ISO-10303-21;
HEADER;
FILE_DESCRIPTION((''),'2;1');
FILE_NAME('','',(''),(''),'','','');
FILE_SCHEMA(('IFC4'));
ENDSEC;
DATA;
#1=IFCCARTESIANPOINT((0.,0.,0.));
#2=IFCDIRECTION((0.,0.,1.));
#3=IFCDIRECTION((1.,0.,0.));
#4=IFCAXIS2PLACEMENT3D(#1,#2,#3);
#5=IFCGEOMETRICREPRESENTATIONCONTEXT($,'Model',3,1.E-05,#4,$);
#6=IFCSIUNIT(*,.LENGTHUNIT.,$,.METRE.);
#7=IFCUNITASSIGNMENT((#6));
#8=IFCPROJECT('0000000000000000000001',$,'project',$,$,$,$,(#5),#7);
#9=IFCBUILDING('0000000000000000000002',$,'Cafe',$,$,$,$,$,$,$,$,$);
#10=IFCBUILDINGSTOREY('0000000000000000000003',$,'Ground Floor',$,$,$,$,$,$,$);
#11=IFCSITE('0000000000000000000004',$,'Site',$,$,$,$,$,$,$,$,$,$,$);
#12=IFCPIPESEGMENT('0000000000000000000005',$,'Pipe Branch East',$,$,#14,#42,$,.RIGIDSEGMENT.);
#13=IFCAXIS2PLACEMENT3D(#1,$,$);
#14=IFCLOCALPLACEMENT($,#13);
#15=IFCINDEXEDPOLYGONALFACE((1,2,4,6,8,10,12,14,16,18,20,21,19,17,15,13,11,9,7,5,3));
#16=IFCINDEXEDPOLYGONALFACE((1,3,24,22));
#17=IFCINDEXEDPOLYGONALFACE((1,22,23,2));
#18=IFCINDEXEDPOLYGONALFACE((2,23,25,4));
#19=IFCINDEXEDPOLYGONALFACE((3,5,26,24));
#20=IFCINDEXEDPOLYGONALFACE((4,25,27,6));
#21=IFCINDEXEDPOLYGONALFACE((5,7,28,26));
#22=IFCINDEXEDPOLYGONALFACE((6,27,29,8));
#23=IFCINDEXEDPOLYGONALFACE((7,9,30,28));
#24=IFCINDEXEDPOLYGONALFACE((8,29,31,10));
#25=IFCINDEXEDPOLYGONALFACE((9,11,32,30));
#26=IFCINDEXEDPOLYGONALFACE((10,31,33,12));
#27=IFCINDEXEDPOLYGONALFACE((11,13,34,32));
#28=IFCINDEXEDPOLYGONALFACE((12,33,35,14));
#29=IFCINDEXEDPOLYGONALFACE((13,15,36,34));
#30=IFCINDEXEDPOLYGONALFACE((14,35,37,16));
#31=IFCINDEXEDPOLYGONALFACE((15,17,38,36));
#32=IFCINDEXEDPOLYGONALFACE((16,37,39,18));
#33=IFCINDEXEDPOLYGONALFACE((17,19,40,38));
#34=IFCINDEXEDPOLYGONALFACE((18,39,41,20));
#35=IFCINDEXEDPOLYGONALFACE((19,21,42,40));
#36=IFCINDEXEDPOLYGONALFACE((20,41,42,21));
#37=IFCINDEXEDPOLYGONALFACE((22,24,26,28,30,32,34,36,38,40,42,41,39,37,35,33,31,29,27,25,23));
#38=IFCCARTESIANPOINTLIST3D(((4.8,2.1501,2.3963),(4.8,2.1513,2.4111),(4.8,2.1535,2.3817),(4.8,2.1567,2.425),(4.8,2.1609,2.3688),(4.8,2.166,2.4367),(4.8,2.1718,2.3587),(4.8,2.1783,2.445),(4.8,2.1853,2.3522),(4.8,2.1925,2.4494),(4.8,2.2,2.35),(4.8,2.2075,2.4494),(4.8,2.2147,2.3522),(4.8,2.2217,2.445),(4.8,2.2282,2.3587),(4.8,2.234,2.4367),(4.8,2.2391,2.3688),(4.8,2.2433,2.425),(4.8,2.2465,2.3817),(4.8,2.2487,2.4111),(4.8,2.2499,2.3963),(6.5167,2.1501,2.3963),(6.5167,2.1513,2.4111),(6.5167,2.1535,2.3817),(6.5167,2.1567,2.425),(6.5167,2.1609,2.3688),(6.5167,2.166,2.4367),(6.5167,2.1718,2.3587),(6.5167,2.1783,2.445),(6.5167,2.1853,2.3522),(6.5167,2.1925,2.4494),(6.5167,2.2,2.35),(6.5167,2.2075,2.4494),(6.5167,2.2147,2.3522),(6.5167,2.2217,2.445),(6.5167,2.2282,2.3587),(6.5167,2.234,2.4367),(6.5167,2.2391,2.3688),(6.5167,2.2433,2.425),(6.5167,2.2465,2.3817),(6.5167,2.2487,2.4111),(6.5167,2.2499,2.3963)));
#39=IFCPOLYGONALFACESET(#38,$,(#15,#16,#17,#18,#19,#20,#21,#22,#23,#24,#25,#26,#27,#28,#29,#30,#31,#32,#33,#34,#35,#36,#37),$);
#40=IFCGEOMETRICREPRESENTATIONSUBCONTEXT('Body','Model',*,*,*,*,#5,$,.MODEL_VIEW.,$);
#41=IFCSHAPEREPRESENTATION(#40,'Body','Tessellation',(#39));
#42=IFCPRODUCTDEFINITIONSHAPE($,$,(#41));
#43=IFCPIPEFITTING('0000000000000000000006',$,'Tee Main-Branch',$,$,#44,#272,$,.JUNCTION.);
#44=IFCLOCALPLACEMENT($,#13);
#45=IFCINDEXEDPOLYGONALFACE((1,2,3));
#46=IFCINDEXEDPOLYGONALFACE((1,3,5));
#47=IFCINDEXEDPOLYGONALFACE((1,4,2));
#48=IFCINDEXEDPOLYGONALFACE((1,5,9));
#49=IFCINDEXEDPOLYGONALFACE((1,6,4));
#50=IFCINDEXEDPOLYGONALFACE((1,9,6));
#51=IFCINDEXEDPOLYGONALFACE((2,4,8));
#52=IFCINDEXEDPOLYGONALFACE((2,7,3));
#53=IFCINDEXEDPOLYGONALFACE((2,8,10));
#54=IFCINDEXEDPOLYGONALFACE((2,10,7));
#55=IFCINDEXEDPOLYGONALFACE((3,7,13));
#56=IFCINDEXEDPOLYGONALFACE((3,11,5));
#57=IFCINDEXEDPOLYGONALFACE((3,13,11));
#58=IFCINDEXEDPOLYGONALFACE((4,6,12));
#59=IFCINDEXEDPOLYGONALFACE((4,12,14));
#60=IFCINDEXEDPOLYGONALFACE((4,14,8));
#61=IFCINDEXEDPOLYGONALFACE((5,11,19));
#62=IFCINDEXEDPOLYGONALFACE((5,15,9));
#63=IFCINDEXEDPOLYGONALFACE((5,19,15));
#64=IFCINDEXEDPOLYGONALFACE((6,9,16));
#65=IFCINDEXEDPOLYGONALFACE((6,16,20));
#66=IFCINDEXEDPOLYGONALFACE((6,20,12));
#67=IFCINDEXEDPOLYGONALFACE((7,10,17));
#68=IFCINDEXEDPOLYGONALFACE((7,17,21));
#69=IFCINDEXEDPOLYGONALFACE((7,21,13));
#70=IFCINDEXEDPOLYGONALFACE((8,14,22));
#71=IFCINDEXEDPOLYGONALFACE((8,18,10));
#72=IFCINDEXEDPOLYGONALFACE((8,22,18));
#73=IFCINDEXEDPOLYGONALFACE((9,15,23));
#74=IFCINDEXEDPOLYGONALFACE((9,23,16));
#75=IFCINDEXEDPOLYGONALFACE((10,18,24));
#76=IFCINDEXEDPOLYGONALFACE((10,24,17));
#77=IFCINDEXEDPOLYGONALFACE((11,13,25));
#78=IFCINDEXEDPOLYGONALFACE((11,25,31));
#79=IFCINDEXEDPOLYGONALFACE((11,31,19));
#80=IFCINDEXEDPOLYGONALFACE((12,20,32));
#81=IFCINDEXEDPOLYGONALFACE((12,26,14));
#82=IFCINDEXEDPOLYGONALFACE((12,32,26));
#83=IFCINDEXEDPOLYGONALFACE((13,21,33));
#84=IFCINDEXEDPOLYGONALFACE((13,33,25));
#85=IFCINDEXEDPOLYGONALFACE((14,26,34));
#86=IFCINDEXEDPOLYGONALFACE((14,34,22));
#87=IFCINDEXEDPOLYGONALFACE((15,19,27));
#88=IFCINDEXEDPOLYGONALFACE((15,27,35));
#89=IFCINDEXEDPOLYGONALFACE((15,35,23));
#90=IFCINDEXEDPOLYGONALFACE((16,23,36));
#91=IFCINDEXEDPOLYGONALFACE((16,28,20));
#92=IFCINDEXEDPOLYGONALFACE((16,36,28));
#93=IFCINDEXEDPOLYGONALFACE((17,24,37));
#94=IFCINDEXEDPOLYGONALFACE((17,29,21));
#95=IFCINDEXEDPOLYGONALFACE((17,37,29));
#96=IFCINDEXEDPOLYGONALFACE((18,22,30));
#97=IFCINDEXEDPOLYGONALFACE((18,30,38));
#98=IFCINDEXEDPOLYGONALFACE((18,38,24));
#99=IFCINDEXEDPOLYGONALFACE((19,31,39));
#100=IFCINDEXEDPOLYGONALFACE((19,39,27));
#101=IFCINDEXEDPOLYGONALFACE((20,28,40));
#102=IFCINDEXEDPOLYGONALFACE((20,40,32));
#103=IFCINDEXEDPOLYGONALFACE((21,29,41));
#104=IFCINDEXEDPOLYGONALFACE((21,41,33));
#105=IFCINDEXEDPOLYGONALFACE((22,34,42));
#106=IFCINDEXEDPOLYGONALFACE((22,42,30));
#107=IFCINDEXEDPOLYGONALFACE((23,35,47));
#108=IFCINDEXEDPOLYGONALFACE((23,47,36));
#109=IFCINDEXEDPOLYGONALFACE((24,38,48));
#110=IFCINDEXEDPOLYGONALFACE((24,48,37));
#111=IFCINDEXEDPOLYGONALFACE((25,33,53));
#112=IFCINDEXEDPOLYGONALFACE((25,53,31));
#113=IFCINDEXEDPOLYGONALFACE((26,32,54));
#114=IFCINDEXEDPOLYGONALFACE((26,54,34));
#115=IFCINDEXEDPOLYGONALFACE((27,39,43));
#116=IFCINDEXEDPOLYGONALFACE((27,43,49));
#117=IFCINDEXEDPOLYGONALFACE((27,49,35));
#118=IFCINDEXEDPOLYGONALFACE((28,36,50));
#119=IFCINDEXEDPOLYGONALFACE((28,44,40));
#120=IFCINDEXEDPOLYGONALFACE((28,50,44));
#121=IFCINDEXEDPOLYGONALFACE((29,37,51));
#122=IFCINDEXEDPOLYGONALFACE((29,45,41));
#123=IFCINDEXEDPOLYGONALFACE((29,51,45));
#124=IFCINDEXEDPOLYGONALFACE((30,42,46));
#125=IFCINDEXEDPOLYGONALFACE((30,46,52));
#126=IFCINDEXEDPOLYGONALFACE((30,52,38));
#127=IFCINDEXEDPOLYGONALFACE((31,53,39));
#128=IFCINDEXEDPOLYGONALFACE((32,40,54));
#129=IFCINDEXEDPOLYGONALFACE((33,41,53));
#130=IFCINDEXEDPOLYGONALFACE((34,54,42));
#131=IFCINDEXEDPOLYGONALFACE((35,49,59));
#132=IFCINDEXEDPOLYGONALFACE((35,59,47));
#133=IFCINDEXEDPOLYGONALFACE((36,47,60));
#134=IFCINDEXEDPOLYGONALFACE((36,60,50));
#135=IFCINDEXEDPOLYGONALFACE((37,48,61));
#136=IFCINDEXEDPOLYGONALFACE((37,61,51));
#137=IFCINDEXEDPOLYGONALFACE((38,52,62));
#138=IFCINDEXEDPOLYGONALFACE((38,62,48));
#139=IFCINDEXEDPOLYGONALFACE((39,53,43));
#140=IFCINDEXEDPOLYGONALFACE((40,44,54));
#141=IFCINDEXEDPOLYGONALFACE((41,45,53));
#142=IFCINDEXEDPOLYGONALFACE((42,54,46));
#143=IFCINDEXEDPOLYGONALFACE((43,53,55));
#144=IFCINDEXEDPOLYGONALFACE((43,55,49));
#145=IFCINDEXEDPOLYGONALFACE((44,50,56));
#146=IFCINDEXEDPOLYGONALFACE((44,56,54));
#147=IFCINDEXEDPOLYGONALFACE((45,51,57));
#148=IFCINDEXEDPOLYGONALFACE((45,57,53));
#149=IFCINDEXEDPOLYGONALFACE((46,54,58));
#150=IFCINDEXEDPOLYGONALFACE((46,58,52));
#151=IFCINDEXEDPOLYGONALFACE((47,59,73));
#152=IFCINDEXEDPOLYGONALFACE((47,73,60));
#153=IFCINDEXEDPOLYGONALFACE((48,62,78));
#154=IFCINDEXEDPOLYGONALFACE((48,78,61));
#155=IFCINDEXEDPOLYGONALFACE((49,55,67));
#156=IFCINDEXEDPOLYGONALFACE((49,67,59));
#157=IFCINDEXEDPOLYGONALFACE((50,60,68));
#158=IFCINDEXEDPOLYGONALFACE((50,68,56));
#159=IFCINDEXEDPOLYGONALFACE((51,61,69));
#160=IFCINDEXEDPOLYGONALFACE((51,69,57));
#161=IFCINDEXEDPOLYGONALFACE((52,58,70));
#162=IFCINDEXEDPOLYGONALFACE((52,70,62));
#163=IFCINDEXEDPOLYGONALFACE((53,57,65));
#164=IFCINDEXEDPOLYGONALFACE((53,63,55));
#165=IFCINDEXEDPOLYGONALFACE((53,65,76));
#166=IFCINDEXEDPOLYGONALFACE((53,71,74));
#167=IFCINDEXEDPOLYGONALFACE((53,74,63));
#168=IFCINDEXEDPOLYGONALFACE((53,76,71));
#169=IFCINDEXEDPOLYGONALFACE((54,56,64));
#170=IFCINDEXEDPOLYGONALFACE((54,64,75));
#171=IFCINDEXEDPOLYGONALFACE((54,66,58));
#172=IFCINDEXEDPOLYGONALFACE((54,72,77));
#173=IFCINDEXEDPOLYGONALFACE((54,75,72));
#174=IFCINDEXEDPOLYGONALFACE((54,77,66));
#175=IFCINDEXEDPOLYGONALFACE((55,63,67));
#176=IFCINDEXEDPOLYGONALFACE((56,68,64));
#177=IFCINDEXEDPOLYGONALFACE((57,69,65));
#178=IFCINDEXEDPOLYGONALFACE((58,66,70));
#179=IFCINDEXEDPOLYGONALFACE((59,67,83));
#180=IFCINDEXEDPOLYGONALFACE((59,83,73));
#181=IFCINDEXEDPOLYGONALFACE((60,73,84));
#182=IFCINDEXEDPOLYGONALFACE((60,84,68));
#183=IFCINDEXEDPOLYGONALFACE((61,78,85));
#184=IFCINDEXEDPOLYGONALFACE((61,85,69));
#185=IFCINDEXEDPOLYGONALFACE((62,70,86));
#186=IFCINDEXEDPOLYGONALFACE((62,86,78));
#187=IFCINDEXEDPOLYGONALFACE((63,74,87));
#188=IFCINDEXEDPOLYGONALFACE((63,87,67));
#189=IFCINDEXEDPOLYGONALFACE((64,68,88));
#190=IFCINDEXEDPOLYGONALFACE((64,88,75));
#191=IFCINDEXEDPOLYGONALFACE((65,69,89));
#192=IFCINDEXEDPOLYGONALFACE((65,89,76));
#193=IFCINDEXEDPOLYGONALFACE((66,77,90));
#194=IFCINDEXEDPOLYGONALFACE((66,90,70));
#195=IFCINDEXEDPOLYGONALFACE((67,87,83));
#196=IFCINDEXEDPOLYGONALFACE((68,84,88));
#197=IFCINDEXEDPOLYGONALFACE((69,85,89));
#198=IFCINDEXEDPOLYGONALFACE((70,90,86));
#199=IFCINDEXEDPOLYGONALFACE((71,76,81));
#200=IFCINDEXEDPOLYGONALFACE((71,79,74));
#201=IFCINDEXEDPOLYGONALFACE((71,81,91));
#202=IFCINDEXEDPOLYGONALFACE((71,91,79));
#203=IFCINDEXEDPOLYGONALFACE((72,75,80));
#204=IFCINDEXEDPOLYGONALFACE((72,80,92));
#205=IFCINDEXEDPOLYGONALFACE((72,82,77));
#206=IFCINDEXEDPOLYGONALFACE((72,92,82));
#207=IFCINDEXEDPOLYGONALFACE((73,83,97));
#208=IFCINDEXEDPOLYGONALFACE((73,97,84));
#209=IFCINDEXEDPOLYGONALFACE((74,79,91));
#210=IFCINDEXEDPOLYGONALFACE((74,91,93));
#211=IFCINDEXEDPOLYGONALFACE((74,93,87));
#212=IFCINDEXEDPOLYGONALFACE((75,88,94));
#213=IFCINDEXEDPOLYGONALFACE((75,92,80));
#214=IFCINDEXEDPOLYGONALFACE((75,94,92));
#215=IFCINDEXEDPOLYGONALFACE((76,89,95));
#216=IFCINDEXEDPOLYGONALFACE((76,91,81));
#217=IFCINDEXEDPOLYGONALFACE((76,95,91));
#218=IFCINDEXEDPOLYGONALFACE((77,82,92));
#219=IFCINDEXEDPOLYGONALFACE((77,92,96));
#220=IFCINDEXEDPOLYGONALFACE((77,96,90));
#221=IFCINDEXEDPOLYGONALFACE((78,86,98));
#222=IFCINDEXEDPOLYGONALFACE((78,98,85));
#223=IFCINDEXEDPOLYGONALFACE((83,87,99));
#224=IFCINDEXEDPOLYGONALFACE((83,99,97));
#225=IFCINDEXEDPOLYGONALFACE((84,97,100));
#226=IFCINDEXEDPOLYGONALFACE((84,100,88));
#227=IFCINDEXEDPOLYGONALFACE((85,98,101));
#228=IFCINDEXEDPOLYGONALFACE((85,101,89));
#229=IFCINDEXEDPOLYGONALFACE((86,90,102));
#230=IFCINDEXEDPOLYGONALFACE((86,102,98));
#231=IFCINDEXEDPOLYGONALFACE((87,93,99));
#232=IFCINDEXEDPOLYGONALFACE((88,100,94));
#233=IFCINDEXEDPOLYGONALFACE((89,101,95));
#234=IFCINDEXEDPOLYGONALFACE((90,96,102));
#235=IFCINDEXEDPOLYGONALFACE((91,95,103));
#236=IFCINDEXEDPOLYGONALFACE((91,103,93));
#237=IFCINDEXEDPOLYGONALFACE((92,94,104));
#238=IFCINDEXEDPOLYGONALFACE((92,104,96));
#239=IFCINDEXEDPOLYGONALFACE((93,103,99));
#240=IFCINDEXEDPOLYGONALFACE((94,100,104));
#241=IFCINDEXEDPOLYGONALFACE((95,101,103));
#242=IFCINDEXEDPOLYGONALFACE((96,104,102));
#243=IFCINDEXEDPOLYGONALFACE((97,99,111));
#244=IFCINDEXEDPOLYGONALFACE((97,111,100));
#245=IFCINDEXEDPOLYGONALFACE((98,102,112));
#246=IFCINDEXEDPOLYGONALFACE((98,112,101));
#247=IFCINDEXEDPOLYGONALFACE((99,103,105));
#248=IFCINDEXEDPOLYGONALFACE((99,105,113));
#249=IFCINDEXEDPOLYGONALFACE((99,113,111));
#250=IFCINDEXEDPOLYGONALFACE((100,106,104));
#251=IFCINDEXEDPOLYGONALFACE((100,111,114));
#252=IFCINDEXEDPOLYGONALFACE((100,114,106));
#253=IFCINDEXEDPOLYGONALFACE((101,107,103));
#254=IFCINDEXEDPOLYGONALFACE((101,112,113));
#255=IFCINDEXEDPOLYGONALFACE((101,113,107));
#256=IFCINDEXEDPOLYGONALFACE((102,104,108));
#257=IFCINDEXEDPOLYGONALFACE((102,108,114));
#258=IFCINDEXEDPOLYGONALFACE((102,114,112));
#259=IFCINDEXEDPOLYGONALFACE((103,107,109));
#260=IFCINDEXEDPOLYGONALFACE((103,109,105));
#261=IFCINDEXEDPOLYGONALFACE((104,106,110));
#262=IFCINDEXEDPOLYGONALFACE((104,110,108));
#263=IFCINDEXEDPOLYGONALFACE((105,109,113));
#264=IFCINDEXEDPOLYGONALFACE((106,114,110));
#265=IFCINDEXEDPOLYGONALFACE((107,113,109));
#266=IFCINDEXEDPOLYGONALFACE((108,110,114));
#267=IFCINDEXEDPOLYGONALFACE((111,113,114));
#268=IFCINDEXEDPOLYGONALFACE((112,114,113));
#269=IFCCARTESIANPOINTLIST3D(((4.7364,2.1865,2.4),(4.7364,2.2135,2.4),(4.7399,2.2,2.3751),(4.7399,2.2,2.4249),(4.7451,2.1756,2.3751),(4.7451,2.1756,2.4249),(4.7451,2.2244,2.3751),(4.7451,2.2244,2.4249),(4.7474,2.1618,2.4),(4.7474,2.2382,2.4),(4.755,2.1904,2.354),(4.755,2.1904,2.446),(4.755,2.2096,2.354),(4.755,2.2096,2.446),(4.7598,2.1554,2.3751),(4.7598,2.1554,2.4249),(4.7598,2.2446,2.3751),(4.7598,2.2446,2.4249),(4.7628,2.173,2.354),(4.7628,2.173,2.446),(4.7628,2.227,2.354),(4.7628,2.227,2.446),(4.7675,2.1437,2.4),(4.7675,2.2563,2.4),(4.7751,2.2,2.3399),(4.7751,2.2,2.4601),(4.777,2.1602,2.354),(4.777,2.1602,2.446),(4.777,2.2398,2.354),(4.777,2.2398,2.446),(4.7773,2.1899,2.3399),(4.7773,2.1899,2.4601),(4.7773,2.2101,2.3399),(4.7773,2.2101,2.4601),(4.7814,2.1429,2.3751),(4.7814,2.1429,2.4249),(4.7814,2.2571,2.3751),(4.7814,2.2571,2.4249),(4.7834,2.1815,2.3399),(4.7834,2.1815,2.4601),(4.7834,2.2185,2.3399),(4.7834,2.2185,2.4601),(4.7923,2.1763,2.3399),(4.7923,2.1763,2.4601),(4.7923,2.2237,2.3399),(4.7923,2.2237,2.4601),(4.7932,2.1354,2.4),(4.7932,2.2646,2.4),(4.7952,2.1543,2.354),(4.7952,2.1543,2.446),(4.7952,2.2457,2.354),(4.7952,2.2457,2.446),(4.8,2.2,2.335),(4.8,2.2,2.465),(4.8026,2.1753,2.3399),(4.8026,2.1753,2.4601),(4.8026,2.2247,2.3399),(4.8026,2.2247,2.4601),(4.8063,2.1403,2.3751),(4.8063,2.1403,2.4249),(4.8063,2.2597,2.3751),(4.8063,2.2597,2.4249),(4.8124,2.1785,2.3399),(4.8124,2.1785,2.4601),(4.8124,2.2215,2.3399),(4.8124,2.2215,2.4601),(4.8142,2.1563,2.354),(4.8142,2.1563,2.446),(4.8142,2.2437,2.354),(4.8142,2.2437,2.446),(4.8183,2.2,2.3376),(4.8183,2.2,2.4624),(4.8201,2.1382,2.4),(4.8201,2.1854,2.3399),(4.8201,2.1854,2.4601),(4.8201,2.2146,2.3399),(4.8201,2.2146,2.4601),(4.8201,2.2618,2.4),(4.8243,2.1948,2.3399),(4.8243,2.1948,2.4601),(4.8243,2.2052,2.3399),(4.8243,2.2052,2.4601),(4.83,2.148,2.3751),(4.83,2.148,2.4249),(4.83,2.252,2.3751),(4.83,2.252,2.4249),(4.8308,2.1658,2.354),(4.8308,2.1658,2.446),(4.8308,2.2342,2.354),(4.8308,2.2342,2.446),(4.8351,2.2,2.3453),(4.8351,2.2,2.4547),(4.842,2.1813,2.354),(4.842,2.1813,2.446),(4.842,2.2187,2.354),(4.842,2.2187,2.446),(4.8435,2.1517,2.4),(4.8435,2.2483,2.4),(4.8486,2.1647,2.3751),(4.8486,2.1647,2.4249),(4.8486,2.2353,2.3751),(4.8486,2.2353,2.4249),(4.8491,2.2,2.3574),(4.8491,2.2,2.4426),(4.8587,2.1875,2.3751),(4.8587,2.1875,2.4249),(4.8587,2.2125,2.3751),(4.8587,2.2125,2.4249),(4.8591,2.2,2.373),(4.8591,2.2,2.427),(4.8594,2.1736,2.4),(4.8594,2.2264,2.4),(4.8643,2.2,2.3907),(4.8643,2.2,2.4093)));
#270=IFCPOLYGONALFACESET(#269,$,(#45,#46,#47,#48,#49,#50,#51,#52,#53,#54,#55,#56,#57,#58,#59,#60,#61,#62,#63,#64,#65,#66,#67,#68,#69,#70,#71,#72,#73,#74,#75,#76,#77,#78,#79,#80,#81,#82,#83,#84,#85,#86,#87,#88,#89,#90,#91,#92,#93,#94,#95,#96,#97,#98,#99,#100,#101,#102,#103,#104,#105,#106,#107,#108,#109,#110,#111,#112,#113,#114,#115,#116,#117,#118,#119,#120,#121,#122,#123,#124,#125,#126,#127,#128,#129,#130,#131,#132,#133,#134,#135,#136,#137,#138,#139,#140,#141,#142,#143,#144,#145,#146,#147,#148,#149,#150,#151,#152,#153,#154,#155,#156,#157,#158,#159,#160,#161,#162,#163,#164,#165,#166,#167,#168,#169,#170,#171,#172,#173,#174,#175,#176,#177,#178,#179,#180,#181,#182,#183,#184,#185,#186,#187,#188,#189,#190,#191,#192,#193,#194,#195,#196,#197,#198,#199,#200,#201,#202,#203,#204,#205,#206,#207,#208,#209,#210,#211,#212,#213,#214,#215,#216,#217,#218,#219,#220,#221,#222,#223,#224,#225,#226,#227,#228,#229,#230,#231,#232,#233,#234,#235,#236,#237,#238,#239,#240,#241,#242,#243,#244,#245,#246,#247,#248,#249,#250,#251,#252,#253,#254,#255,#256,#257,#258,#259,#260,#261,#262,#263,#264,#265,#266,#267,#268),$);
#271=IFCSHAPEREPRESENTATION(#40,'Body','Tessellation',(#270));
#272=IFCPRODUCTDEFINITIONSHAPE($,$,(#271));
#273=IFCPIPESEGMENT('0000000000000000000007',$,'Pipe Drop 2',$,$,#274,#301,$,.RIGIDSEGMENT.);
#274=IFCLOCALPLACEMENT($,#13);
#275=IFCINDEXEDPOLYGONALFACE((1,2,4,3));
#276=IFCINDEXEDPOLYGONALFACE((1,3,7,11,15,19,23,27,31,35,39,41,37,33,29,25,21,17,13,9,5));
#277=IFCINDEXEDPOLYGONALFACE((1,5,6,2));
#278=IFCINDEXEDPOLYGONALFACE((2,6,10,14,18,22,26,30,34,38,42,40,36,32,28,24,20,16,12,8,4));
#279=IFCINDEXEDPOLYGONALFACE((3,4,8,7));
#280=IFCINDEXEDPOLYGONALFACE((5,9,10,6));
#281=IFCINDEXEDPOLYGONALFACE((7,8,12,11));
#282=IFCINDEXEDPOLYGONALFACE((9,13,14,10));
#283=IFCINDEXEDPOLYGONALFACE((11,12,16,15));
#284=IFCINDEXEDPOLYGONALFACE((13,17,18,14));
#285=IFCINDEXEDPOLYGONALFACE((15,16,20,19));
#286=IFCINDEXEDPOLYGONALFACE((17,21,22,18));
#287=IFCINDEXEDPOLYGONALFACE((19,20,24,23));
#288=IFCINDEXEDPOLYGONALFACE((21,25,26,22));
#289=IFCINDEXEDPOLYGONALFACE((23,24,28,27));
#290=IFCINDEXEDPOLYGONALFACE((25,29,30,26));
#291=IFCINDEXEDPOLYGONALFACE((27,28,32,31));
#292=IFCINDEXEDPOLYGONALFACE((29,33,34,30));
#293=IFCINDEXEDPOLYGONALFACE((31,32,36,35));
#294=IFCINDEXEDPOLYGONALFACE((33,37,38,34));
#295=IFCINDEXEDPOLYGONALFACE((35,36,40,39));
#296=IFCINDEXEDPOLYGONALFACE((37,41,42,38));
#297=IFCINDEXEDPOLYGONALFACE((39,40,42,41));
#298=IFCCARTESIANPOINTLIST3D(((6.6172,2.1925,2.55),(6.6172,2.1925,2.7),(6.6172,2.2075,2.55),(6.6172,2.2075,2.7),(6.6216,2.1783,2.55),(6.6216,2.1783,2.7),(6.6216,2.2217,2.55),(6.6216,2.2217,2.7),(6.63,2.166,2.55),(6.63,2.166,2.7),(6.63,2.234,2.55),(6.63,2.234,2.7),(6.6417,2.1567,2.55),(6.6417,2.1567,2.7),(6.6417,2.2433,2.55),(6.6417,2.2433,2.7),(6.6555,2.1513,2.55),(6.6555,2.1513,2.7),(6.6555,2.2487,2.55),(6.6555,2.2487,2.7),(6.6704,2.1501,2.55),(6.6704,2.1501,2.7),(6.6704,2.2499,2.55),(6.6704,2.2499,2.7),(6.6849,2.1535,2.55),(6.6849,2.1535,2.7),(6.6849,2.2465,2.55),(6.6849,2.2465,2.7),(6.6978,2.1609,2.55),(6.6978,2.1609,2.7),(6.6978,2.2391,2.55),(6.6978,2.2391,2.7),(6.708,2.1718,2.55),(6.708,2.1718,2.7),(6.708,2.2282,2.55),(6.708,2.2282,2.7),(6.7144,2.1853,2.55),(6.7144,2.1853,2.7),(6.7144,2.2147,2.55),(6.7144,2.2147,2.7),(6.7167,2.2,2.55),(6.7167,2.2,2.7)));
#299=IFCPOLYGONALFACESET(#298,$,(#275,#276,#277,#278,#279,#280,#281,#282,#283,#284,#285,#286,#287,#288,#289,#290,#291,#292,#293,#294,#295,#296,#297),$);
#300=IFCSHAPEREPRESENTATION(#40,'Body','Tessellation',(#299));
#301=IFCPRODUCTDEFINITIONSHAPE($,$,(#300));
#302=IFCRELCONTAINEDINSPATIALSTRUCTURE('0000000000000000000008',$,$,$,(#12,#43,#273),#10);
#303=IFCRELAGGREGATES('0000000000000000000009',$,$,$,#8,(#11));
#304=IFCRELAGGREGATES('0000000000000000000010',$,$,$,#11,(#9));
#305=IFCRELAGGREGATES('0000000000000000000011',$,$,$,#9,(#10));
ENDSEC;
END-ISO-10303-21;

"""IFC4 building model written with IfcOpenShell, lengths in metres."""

from ifc_helpers import new_model, entity, si_unit, frame, origin, origin_with_axes, origin_2d, place, context, subcontext, project, spatial, circle, extrude, element, save


model = new_model("IFC4")

# Units and contexts
model_context = context("Model", 3, precision=1e-05, world=origin_with_axes())
body_context = subcontext(model_context, "Body", "Model", "MODEL_VIEW")
ifc_project = project(units=[si_unit("LENGTHUNIT", "METRE")], contexts=[model_context])

# Site, building, storey
site = spatial("IfcSite", under=ifc_project, Name="Site")
building = spatial("IfcBuilding", under=site, Name="Cafe")
storey = spatial("IfcBuildingStorey", under=building, Name="Ground Floor")

# Pipe segment
pipe_segment_1_placement = place(None, frame((4.8, 2.2, 2.4), z_axis=(1.0, 0.0, 0.0), x_axis=(0.0, 0.0, -1.0)))
element("IfcPipeSegment", 1, at=pipe_segment_1_placement, inside=storey, Name="Pipe Branch East", PredefinedType="RIGIDSEGMENT", context=body_context, shape_type="SweptSolid", body=[
    extrude(circle(Radius=0.05, at=origin_2d()), origin(), (0.0, 0.0, 1.0), 1.7167),
])

# Pipe fitting
pipe_fitting_1_placement = place(None, frame((4.8, 2.2, 2.4), z_axis=(0.0, 0.0, 1.0), x_axis=(1.0, 0.0, 0.0)))
element("IfcPipeFitting", 2, at=pipe_fitting_1_placement, inside=storey, Name="Tee Main-Branch", PredefinedType="JUNCTION", context=body_context, shape_type="CSG", body=[
    entity("IfcCsgSolid", entity("IfcSphere", entity("IfcAxis2Placement3D", entity("IfcCartesianPoint", [0.0, 0.0, 0.0])), 0.065)),
])

# Pipe segment
pipe_segment_2_placement = place(None, frame((6.6667, 2.2, 2.55), z_axis=(0.0, 0.0, 1.0), x_axis=(1.0, 0.0, 0.0)))
element("IfcPipeSegment", 3, at=pipe_segment_2_placement, inside=storey, Name="Pipe Drop 2", PredefinedType="RIGIDSEGMENT", context=body_context, shape_type="SweptSolid", body=[
    extrude(circle(Radius=0.05, at=origin_2d()), origin(), (0.0, 0.0, 1.0), 0.15),
])

save(model, "model.ifc")
